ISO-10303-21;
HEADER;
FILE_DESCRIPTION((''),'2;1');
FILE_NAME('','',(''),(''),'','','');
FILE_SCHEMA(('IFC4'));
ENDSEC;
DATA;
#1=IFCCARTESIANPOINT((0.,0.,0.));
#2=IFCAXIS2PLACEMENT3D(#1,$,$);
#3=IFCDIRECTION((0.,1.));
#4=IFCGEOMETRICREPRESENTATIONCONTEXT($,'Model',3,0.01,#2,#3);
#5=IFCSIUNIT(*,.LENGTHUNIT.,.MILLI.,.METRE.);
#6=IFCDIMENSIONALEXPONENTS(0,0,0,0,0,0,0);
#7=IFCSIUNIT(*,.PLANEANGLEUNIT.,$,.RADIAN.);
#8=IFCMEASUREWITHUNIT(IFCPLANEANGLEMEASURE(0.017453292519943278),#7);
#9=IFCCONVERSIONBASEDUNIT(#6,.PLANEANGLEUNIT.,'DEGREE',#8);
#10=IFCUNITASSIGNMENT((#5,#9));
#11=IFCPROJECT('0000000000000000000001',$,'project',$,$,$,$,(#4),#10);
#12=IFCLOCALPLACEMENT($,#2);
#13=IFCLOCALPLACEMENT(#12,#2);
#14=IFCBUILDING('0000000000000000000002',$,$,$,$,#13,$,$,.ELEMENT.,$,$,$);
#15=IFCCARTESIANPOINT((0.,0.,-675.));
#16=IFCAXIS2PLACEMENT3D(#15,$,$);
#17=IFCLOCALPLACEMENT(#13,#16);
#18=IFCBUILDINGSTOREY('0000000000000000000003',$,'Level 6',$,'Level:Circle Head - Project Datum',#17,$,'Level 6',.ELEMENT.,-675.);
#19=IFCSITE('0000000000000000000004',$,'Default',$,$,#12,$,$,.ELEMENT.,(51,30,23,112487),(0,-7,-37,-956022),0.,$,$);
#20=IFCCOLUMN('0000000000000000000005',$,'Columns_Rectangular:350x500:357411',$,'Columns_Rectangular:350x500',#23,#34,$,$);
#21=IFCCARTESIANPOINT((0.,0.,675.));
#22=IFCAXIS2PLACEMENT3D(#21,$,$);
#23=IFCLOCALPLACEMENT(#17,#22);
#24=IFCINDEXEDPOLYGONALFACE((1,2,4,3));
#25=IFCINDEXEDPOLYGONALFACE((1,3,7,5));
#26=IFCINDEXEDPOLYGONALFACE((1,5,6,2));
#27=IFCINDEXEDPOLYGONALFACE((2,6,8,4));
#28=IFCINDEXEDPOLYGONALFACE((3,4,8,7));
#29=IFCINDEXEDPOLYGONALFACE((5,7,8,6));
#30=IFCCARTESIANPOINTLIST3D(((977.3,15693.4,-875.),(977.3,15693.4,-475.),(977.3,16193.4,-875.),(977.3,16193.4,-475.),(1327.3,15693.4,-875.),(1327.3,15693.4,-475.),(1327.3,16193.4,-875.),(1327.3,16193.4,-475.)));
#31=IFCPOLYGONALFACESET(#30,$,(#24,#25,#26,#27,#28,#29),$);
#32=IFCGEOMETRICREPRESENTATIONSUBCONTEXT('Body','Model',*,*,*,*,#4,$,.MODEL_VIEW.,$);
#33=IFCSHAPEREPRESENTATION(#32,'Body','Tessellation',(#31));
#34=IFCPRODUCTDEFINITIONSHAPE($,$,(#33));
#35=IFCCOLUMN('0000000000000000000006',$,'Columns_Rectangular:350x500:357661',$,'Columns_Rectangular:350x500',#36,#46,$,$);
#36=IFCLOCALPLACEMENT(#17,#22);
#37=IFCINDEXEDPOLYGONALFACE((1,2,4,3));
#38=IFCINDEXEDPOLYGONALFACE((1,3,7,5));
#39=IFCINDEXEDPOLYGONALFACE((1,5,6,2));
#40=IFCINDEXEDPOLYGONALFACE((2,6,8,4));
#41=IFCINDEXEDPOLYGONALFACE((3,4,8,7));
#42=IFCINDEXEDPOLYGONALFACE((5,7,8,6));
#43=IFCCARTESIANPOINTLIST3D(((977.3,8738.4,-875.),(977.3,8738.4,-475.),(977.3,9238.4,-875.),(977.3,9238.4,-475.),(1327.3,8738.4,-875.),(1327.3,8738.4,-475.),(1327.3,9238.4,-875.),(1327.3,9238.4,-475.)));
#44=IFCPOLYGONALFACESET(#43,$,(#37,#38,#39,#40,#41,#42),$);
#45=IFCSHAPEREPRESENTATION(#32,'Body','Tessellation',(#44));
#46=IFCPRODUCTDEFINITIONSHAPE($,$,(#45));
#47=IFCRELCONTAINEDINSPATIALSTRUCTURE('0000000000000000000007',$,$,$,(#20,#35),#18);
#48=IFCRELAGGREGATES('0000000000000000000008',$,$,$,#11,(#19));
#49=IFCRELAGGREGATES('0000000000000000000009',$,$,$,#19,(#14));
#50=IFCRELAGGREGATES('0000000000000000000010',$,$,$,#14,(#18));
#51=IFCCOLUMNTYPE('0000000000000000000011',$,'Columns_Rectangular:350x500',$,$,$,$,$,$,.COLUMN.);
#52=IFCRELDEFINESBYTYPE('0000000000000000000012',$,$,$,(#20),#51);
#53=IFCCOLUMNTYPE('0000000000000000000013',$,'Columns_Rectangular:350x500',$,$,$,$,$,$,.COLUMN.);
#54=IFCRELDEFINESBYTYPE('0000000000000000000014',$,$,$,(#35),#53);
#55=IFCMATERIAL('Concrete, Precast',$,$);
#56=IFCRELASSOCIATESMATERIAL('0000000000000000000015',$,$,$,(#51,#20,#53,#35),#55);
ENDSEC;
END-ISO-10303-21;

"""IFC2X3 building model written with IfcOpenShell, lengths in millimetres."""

from ifc_helpers import new_model, entity, si_unit, converted_unit, direction, frame, frame_2d, origin, place, context, subcontext, project, spatial, rectangle, extrude, source, transform, mapped, material, type_object, type_shapes, element, save


model = new_model("IFC2X3")

# Units and contexts
model_context = context("Model", 3, precision=0.01, world=origin(), true_north=direction((0.0, 1.0)))
body_context = subcontext(model_context, "Body", "Model", "MODEL_VIEW")
ifc_project = project(units=[si_unit("LENGTHUNIT", "METRE", prefix="MILLI"), converted_unit("PLANEANGLEUNIT", "DEGREE", entity("IfcPlaneAngleMeasure", 0.017453292519943278), si_unit("PLANEANGLEUNIT", "RADIAN"), dimensions=[0, 0, 0, 0, 0, 0, 0])], contexts=[model_context])

# Site, building, storey
site_placement = place(None, origin())
site = spatial("IfcSite", under=ifc_project, at=site_placement, Name="Default", CompositionType="ELEMENT", RefLatitude=(51, 30, 23, 112487), RefLongitude=(0, -7, -37, -956022), RefElevation=0.0)
building_placement = place(site_placement, origin())
building = spatial("IfcBuilding", under=site, at=building_placement, CompositionType="ELEMENT")
storey_placement = place(building_placement, frame((0.0, 0.0, -675.0)))
storey = spatial("IfcBuildingStorey", under=building, at=storey_placement, Name="Level 6", ObjectType="Level:Circle Head - Project Datum", LongName="Level 6", CompositionType="ELEMENT", Elevation=-675.0)

# Columns
ifc_material = material(Name="Concrete, Precast")
column_type_1 = type_object("IfcColumnType", Name="Columns_Rectangular:350x500", PredefinedType="COLUMN", material=ifc_material)
shared_shape_1 = source(origin(), body_context, "Body", "SweptSolid", [
    extrude(rectangle(XDim=350.0, YDim=500.0, at=frame_2d((0.0, 0.0), x_axis=(1.0, 0.0))), frame((1152.3, 15943.4, -875.0), z_axis=(0.0, 0.0, 1.0), x_axis=(-1.0, 0.0, 0.0)), (0.0, 0.0, 1.0), 400.0),
])
type_shapes(column_type_1, [shared_shape_1])
column_1_placement = place(storey_placement, frame((0.0, 0.0, 675.0)))
element("IfcColumn", 1, at=column_1_placement, inside=storey, type_object=column_type_1, material=ifc_material, Name="Columns_Rectangular:350x500:357411", ObjectType="Columns_Rectangular:350x500", context=body_context, shape_type="MappedRepresentation", body=[
    mapped(shared_shape_1, transform((0.0, 0.0, 0.0), scale=1.0)),
])
column_type_2 = type_object("IfcColumnType", Name="Columns_Rectangular:350x500", PredefinedType="COLUMN", material=ifc_material)
shared_shape_2 = source(origin(), body_context, "Body", "SweptSolid", [
    extrude(rectangle(XDim=350.0, YDim=500.0, at=frame_2d((0.0, 0.0), x_axis=(1.0, 0.0))), frame((1152.3, 8988.4, -875.0), z_axis=(0.0, 0.0, 1.0), x_axis=(-1.0, 0.0, 0.0)), (0.0, 0.0, 1.0), 400.0),
])
type_shapes(column_type_2, [shared_shape_2])
column_2_placement = place(storey_placement, frame((0.0, 0.0, 675.0)))
element("IfcColumn", 2, at=column_2_placement, inside=storey, type_object=column_type_2, material=ifc_material, Name="Columns_Rectangular:350x500:357661", ObjectType="Columns_Rectangular:350x500", context=body_context, shape_type="MappedRepresentation", body=[
    mapped(shared_shape_2, transform((0.0, 0.0, 0.0), scale=1.0)),
])

save(model, "model.ifc")
